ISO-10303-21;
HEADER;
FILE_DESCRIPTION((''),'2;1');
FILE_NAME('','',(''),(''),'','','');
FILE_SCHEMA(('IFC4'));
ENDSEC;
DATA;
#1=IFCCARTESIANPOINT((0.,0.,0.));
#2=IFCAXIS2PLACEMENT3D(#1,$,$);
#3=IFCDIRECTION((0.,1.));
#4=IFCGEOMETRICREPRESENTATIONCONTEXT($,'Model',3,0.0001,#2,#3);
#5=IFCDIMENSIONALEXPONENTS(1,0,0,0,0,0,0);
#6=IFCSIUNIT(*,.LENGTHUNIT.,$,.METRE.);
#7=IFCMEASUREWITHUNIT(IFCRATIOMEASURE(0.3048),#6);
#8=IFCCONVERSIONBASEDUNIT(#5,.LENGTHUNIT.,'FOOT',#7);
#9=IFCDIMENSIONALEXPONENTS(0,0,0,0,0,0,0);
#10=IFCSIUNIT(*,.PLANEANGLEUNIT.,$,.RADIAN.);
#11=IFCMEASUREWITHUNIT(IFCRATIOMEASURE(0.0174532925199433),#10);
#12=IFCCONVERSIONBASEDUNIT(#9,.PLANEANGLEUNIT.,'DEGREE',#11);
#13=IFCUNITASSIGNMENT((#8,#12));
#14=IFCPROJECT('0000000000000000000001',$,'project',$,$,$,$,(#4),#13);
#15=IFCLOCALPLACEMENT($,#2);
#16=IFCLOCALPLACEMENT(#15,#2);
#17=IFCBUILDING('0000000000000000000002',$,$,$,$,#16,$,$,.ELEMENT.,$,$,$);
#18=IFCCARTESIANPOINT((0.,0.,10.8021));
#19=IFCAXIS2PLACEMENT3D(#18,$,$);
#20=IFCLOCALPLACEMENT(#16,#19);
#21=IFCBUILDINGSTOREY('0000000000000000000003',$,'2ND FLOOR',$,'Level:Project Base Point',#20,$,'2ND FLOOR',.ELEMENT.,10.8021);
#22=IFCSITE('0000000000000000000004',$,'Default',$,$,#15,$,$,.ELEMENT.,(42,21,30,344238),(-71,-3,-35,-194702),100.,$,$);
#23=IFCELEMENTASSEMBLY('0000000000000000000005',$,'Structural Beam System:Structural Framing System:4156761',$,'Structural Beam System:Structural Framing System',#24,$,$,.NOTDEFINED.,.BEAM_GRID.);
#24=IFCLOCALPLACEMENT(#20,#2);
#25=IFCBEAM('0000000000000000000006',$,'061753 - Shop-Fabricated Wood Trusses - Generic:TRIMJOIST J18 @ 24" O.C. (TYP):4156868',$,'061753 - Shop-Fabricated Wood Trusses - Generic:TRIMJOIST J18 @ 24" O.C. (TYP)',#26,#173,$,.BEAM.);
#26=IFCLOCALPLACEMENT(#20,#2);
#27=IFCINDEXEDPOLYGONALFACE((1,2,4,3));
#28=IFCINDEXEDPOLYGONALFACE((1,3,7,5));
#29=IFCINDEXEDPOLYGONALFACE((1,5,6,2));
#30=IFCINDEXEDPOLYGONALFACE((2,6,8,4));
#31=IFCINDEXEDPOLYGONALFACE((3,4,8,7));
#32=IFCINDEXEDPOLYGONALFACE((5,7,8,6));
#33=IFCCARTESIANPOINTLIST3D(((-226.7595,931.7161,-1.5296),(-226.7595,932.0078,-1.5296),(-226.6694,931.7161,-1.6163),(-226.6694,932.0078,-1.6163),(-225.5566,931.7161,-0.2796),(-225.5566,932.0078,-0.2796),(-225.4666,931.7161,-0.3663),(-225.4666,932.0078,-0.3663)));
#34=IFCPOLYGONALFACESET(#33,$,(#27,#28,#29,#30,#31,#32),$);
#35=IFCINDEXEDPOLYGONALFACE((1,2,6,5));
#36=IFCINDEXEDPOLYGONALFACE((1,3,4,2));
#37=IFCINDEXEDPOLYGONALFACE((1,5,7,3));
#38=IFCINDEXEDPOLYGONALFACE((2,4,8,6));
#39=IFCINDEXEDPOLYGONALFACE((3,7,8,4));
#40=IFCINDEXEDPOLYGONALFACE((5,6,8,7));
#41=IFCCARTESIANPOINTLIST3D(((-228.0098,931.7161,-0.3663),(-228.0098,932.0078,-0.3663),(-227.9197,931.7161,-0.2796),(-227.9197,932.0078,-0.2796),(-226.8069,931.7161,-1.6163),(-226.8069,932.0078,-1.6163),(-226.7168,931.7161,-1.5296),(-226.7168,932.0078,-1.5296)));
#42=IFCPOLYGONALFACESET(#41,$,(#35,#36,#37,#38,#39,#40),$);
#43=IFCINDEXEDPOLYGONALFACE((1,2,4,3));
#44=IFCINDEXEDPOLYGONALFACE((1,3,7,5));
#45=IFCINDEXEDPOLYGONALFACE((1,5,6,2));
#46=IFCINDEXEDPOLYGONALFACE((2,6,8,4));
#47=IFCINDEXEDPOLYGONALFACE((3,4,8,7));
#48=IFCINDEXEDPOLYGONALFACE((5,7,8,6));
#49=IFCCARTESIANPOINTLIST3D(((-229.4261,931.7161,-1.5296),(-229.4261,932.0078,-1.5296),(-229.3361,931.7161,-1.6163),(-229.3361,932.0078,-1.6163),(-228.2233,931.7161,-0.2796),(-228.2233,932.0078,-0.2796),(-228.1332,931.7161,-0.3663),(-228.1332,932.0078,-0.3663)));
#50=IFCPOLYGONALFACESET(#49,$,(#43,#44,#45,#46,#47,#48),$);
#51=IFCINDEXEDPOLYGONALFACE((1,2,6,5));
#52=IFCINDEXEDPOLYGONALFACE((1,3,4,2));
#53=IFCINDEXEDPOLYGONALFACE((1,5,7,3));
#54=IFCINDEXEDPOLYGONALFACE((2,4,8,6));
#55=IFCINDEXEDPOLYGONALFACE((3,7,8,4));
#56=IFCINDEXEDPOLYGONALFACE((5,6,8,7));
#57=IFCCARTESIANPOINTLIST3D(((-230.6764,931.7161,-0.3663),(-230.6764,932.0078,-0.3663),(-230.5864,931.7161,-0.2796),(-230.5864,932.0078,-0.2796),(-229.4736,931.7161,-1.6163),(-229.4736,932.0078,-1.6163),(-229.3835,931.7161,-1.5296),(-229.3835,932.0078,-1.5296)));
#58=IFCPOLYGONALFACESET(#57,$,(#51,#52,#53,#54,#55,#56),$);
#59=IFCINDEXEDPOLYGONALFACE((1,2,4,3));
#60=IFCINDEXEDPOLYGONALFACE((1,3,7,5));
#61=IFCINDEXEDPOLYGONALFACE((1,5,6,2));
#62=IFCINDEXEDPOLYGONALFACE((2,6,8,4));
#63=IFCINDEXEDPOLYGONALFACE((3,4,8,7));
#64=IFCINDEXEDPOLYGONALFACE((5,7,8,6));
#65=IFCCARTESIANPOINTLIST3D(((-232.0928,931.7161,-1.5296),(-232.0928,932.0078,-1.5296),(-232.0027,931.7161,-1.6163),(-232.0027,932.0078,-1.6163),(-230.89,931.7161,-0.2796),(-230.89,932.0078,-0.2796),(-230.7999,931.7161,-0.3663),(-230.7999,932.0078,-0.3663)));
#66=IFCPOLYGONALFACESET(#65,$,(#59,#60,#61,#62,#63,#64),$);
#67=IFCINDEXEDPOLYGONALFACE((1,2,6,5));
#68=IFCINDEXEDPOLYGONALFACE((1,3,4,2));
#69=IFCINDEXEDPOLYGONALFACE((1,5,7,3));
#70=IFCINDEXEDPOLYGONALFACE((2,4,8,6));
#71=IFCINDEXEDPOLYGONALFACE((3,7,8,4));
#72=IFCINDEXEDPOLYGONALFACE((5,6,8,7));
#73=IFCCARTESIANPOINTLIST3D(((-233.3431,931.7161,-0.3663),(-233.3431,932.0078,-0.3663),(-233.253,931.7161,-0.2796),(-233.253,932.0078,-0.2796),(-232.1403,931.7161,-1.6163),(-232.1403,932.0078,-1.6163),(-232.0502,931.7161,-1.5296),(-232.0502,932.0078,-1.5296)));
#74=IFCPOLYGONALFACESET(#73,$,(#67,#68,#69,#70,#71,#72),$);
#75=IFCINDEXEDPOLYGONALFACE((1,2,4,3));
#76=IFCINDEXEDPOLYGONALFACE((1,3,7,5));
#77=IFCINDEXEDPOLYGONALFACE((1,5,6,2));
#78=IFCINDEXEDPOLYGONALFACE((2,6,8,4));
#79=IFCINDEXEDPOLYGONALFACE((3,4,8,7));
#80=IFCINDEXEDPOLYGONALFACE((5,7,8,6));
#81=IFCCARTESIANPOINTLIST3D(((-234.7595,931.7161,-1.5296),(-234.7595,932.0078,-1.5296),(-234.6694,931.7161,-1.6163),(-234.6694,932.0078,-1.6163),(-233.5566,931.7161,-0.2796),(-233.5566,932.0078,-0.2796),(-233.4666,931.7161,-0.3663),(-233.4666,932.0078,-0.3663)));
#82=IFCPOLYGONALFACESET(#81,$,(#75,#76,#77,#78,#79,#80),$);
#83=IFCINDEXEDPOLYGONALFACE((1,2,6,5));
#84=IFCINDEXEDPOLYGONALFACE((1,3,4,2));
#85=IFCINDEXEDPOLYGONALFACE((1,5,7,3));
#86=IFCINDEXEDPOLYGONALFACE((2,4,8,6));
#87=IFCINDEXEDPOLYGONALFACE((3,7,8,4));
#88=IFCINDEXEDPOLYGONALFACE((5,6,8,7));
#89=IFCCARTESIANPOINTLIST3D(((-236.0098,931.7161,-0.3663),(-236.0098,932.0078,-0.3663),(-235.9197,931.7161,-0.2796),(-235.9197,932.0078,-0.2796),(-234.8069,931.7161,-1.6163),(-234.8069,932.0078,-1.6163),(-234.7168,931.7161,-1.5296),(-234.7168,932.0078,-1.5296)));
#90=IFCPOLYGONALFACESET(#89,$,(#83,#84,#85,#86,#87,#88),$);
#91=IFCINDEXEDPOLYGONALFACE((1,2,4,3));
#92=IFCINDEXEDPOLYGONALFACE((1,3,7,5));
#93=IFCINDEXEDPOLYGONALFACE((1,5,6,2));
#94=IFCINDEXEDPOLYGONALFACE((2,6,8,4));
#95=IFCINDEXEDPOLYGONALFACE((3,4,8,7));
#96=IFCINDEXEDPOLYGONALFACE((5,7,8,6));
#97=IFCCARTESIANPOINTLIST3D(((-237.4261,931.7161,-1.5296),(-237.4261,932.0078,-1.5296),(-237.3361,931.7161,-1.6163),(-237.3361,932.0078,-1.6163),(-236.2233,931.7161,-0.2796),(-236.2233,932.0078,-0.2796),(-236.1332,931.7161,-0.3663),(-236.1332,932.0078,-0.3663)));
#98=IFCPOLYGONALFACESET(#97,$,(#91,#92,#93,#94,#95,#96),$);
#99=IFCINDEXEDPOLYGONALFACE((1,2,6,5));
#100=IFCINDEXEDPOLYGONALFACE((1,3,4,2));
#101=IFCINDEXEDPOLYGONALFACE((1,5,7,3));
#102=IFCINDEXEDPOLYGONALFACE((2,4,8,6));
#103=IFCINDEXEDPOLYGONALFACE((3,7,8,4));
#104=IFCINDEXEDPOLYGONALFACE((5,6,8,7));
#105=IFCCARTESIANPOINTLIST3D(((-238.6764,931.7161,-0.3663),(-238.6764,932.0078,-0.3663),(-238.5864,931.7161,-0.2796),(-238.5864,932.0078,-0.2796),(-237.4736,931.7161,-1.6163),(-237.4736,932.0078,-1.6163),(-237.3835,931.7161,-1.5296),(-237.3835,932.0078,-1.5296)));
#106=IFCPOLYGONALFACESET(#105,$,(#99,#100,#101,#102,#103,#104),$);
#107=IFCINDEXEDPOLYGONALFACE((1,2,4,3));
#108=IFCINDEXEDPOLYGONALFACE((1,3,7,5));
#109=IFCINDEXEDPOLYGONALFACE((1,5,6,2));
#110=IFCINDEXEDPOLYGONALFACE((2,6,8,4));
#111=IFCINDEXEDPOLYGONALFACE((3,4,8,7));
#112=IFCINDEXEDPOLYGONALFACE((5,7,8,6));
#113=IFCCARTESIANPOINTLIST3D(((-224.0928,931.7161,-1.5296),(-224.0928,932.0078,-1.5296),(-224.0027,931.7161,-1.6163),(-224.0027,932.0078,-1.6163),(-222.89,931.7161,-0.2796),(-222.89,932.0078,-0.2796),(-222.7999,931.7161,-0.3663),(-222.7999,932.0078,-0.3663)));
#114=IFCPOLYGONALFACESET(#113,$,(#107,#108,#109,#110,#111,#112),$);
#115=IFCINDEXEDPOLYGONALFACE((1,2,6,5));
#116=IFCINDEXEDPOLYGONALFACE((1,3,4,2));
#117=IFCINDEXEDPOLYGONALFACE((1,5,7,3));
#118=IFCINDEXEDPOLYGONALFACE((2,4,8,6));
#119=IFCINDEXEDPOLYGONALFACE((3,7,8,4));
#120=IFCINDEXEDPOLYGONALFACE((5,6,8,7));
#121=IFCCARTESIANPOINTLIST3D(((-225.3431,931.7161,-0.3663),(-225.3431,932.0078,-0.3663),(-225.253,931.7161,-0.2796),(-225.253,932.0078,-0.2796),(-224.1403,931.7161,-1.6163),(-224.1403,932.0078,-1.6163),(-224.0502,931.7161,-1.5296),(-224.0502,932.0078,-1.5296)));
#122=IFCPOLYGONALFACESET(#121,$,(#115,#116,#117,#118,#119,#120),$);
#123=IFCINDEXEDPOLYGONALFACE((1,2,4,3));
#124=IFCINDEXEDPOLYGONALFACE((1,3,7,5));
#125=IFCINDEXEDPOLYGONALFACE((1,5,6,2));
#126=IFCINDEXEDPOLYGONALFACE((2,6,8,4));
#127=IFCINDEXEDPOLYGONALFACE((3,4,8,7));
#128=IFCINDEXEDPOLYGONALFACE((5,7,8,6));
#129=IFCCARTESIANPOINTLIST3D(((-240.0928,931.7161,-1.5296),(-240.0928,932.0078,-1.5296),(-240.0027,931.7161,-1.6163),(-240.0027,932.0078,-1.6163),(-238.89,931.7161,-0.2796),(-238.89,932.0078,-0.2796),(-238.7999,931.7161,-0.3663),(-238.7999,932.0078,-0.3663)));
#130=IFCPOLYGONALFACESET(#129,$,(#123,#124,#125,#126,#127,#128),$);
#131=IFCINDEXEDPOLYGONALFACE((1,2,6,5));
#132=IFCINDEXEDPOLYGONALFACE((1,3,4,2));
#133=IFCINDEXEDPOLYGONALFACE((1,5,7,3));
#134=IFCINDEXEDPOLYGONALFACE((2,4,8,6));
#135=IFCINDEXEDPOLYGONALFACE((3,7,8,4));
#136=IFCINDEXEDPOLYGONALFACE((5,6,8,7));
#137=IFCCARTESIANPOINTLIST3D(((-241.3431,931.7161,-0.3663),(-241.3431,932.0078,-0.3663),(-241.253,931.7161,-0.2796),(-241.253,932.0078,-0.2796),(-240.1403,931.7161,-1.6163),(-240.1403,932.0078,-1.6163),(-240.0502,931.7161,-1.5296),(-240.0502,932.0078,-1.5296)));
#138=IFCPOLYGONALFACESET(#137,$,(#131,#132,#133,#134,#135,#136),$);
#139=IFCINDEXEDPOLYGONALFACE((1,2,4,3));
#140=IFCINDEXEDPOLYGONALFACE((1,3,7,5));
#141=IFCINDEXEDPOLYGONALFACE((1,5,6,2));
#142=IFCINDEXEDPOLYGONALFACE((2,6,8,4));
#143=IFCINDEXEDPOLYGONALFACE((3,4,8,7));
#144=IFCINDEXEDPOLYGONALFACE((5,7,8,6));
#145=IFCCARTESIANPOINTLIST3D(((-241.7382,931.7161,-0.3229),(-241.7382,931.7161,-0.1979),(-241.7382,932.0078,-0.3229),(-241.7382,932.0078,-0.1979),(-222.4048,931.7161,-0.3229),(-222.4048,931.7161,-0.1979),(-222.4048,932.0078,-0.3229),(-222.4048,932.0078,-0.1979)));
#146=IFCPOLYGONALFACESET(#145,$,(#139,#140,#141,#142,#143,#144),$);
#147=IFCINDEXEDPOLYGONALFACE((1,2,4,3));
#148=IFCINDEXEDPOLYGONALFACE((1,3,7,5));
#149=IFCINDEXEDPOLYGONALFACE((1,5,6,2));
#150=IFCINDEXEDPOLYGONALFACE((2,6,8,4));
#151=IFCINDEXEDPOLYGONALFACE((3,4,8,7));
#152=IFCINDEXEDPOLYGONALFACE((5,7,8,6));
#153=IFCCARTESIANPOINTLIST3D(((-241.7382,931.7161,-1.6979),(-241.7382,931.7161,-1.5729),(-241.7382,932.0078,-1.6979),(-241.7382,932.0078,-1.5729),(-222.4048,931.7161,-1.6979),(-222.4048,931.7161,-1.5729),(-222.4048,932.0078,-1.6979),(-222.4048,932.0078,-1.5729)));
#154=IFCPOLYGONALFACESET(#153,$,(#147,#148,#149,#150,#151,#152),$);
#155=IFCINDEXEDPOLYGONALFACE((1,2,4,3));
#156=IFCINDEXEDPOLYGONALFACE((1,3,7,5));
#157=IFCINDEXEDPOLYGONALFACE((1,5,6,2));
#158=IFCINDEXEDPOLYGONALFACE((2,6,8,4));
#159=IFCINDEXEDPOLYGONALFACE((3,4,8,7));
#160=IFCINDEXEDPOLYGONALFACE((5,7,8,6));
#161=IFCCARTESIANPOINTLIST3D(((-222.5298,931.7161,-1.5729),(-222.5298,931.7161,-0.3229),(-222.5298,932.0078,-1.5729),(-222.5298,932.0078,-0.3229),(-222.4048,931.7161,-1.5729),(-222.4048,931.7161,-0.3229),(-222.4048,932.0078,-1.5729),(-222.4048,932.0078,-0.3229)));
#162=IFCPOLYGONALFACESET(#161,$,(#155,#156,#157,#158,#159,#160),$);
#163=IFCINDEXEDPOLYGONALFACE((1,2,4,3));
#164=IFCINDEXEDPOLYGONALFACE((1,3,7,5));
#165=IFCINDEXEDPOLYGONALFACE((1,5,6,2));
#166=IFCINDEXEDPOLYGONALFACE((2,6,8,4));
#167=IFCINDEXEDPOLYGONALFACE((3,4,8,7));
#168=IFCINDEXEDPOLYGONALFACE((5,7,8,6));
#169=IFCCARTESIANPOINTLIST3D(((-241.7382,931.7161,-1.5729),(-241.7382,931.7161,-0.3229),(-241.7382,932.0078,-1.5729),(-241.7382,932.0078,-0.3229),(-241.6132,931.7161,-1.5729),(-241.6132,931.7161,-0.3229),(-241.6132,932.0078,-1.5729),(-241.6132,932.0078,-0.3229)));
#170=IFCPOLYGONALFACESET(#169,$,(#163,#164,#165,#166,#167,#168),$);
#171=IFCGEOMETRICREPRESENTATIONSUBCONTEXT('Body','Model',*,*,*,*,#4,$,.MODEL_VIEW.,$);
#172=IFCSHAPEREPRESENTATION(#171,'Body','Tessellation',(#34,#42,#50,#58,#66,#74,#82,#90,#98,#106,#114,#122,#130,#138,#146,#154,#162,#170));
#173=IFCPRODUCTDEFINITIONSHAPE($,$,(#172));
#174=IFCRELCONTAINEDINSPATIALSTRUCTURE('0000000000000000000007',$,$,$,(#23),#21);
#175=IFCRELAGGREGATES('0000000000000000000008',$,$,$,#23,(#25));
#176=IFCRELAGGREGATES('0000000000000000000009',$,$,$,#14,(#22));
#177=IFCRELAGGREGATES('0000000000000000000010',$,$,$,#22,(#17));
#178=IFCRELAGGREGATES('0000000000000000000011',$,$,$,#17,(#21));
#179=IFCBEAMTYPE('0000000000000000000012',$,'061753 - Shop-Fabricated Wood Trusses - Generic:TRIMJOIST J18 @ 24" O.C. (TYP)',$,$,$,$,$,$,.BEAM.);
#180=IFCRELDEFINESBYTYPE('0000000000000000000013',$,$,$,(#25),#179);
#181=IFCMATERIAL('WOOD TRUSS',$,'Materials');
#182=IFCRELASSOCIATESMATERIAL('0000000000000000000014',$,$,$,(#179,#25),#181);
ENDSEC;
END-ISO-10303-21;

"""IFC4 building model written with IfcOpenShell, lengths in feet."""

from ifc_helpers import new_model, entity, si_unit, converted_unit, direction, frame, frame_2d, origin, origin_2d_with_axis, place, context, subcontext, project, spatial, rectangle, extrude, source, transform, mapped, material, material_profile, profile_set, profile_usage, type_object, type_shapes, element, aggregate, save


model = new_model("IFC4")

# Units and contexts
model_context = context("Model", 3, precision=0.0001, world=origin(), true_north=direction((0.0, 1.0)))
body_context = subcontext(model_context, "Body", "Model", "MODEL_VIEW")
ifc_project = project(units=[converted_unit("LENGTHUNIT", "FOOT", entity("IfcRatioMeasure", 0.3048), si_unit("LENGTHUNIT", "METRE"), dimensions=[1, 0, 0, 0, 0, 0, 0]), converted_unit("PLANEANGLEUNIT", "DEGREE", entity("IfcRatioMeasure", 0.0174532925199433), si_unit("PLANEANGLEUNIT", "RADIAN"), dimensions=[0, 0, 0, 0, 0, 0, 0])], contexts=[model_context])

# Site, building, storey
site_placement = place(None, origin())
site = spatial("IfcSite", under=ifc_project, at=site_placement, Name="Default", CompositionType="ELEMENT", RefLatitude=(42, 21, 30, 344238), RefLongitude=(-71, -3, -35, -194702), RefElevation=100.0)
building_placement = place(site_placement, origin())
building = spatial("IfcBuilding", under=site, at=building_placement, CompositionType="ELEMENT")
storey_placement = place(building_placement, frame((0.0, 0.0, 10.8021)))
storey = spatial("IfcBuildingStorey", under=building, at=storey_placement, Name="2ND FLOOR", ObjectType="Level:Project Base Point", LongName="2ND FLOOR", CompositionType="ELEMENT", Elevation=10.8021)

# Element assembly, beam
ifc_material_1 = material(Name="WOOD TRUSS", Category="Materials")
ifc_material_profile_1 = material_profile(ifc_material_1, rectangle(XDim=1.7347, YDim=0.125, at=frame_2d((0.0, 0.0), x_axis=(1.0, 0.0))), Name="TRIMJOIST J18 @ 24\" O.C. (TYP)")
ifc_material_profile_2 = material_profile(ifc_material_1, rectangle(XDim=1.7347, YDim=0.125, at=frame_2d((0.0, 0.0), x_axis=(1.0, 0.0))), Name="TRIMJOIST J18 @ 24\" O.C. (TYP)")
ifc_material_profile_3 = material_profile(ifc_material_1, rectangle(XDim=1.7347, YDim=0.125, at=frame_2d((0.0, 0.0), x_axis=(1.0, 0.0))), Name="TRIMJOIST J18 @ 24\" O.C. (TYP)")
ifc_material_profile_4 = material_profile(ifc_material_1, rectangle(XDim=1.7347, YDim=0.125, at=frame_2d((0.0, 0.0), x_axis=(1.0, 0.0))), Name="TRIMJOIST J18 @ 24\" O.C. (TYP)")
ifc_material_profile_5 = material_profile(ifc_material_1, rectangle(XDim=1.7347, YDim=0.125, at=frame_2d((0.0, 0.0), x_axis=(1.0, 0.0))), Name="TRIMJOIST J18 @ 24\" O.C. (TYP)")
ifc_material_profile_6 = material_profile(ifc_material_1, rectangle(XDim=1.7347, YDim=0.125, at=frame_2d((0.0, 0.0), x_axis=(1.0, 0.0))), Name="TRIMJOIST J18 @ 24\" O.C. (TYP)")
ifc_material_profile_7 = material_profile(ifc_material_1, rectangle(XDim=1.7347, YDim=0.125, at=frame_2d((0.0, 0.0), x_axis=(1.0, 0.0))), Name="TRIMJOIST J18 @ 24\" O.C. (TYP)")
ifc_material_profile_8 = material_profile(ifc_material_1, rectangle(XDim=1.7347, YDim=0.125, at=frame_2d((0.0, 0.0), x_axis=(1.0, 0.0))), Name="TRIMJOIST J18 @ 24\" O.C. (TYP)")
ifc_material_profile_9 = material_profile(ifc_material_1, rectangle(XDim=1.7347, YDim=0.125, at=frame_2d((0.0, 0.0), x_axis=(1.0, 0.0))), Name="TRIMJOIST J18 @ 24\" O.C. (TYP)")
ifc_material_profile_10 = material_profile(ifc_material_1, rectangle(XDim=1.7347, YDim=0.125, at=origin_2d_with_axis()), Name="TRIMJOIST J18 @ 24\" O.C. (TYP)")
ifc_material_profile_11 = material_profile(ifc_material_1, rectangle(XDim=0.125, YDim=0.2917, at=origin_2d_with_axis()), Name="TRIMJOIST J18 @ 24\" O.C. (TYP)")
ifc_material_profile_12 = material_profile(ifc_material_1, rectangle(XDim=0.125, YDim=0.2917, at=origin_2d_with_axis()), Name="TRIMJOIST J18 @ 24\" O.C. (TYP)")
ifc_material_profile_13 = material_profile(ifc_material_1, rectangle(XDim=1.25, YDim=0.2917, at=origin_2d_with_axis()), Name="TRIMJOIST J18 @ 24\" O.C. (TYP)")
ifc_material_profile_14 = material_profile(ifc_material_1, rectangle(XDim=1.25, YDim=0.2917, at=origin_2d_with_axis()), Name="TRIMJOIST J18 @ 24\" O.C. (TYP)")
ifc_profile_set_1 = profile_set([ifc_material_profile_1, ifc_material_profile_2, ifc_material_profile_3, ifc_material_profile_4, ifc_material_profile_5, ifc_material_profile_6, ifc_material_profile_7, ifc_material_profile_8, ifc_material_profile_9, ifc_material_profile_10, ifc_material_profile_11, ifc_material_profile_12, ifc_material_profile_13, ifc_material_profile_14], Name="TRIMJOIST J18 @ 24\" O.C. (TYP)")
assembly_1_placement = place(storey_placement, origin())
assembly_1 = element("IfcElementAssembly", 1, at=assembly_1_placement, inside=storey, Name="Structural Beam System:Structural Framing System:4156761", ObjectType="Structural Beam System:Structural Framing System", AssemblyPlace="NOTDEFINED", PredefinedType="BEAM_GRID")
beam_type_1 = type_object("IfcBeamType", Name="061753 - Shop-Fabricated Wood Trusses - Generic:TRIMJOIST J18 @ 24\" O.C. (TYP)", PredefinedType="BEAM", material=ifc_profile_set_1)
shared_shape_1 = source(origin(), body_context, "Body", "SweptSolid", [
    extrude(rectangle(XDim=1.7347, YDim=0.125, at=frame_2d((0.0, 0.0), x_axis=(1.0, 0.0))), frame((5.9585, -0.1458, 0.0), z_axis=(0.0, 1.0, 0.0), x_axis=(0.693383, 0.0, 0.720569)), (0.0, 0.0, 1.0), 0.2917),
    extrude(rectangle(XDim=1.7347, YDim=0.125, at=origin_2d_with_axis()), frame((4.7082, -0.1458, 0.0), z_axis=(0.0, 1.0, 0.0), x_axis=(0.693383, 0.0, -0.720569)), (0.0, 0.0, 1.0), 0.2917),
    extrude(rectangle(XDim=1.7347, YDim=0.125, at=frame_2d((0.0, 0.0), x_axis=(1.0, 0.0))), frame((3.2918, -0.1458, 0.0), z_axis=(0.0, 1.0, 0.0), x_axis=(0.693383, 0.0, 0.720569)), (0.0, 0.0, 1.0), 0.2917),
    extrude(rectangle(XDim=1.7347, YDim=0.125, at=frame_2d((0.0, 0.0), x_axis=(1.0, 0.0))), frame((2.0415, -0.1458, 0.0), z_axis=(0.0, 1.0, 0.0), x_axis=(0.693383, 0.0, -0.720569)), (0.0, 0.0, 1.0), 0.2917),
    extrude(rectangle(XDim=1.7347, YDim=0.125, at=frame_2d((0.0, 0.0), x_axis=(1.0, 0.0))), frame((0.6251, -0.1458, 0.0), z_axis=(0.0, 1.0, 0.0), x_axis=(0.693383, 0.0, 0.720569)), (0.0, 0.0, 1.0), 0.2917),
    extrude(rectangle(XDim=1.7347, YDim=0.125, at=frame_2d((0.0, 0.0), x_axis=(1.0, 0.0))), frame((-0.6251, -0.1458, 0.0), z_axis=(0.0, 1.0, 0.0), x_axis=(0.693383, 0.0, -0.720569)), (0.0, 0.0, 1.0), 0.2917),
    extrude(rectangle(XDim=1.7347, YDim=0.125, at=frame_2d((0.0, 0.0), x_axis=(1.0, 0.0))), frame((-2.0415, -0.1458, 0.0), z_axis=(0.0, 1.0, 0.0), x_axis=(0.693383, 0.0, 0.720569)), (0.0, 0.0, 1.0), 0.2917),
    extrude(rectangle(XDim=1.7347, YDim=0.125, at=origin_2d_with_axis()), frame((-3.2918, -0.1458, 0.0), z_axis=(0.0, 1.0, 0.0), x_axis=(0.693383, 0.0, -0.720569)), (0.0, 0.0, 1.0), 0.2917),
    extrude(rectangle(XDim=1.7347, YDim=0.125, at=frame_2d((0.0, 0.0), x_axis=(1.0, 0.0))), frame((-4.7082, -0.1458, 0.0), z_axis=(0.0, 1.0, 0.0), x_axis=(0.693383, 0.0, 0.720569)), (0.0, 0.0, 1.0), 0.2917),
    extrude(rectangle(XDim=1.7347, YDim=0.125, at=frame_2d((0.0, 0.0), x_axis=(1.0, 0.0))), frame((-5.9585, -0.1458, 0.0), z_axis=(0.0, 1.0, 0.0), x_axis=(0.693383, 0.0, -0.720569)), (0.0, 0.0, 1.0), 0.2917),
    extrude(rectangle(XDim=1.7347, YDim=0.125, at=frame_2d((0.0, 0.0), x_axis=(1.0, 0.0))), frame((8.6251, -0.1458, 0.0), z_axis=(0.0, 1.0, 0.0), x_axis=(0.693383, 0.0, 0.720569)), (0.0, 0.0, 1.0), 0.2917),
    extrude(rectangle(XDim=1.7347, YDim=0.125, at=origin_2d_with_axis()), frame((7.3749, -0.1458, 0.0), z_axis=(0.0, 1.0, 0.0), x_axis=(0.693383, 0.0, -0.720569)), (0.0, 0.0, 1.0), 0.2917),
    extrude(rectangle(XDim=1.7347, YDim=0.125, at=frame_2d((0.0, 0.0), x_axis=(1.0, 0.0))), frame((-7.3749, -0.1458, 0.0), z_axis=(0.0, 1.0, 0.0), x_axis=(0.693383, 0.0, 0.720569)), (0.0, 0.0, 1.0), 0.2917),
    extrude(rectangle(XDim=1.7347, YDim=0.125, at=origin_2d_with_axis()), frame((-8.6251, -0.1458, 0.0), z_axis=(0.0, 1.0, 0.0), x_axis=(0.693383, 0.0, -0.720569)), (0.0, 0.0, 1.0), 0.2917),
    extrude(rectangle(XDim=0.125, YDim=0.2917, at=origin_2d_with_axis()), frame((-9.6667, 0.0, 0.6875), z_axis=(1.0, 0.0, 0.0), x_axis=(0.0, 0.0, -1.0)), (0.0, 0.0, 1.0), 19.3333),
    extrude(rectangle(XDim=0.125, YDim=0.2917, at=origin_2d_with_axis()), frame((-9.6667, 0.0, -0.6875), z_axis=(1.0, 0.0, 0.0), x_axis=(0.0, 0.0, -1.0)), (0.0, 0.0, 1.0), 19.3333),
    extrude(rectangle(XDim=1.25, YDim=0.2917, at=origin_2d_with_axis()), frame((9.5417, 0.0, 0.0), z_axis=(1.0, 0.0, 0.0), x_axis=(0.0, 0.0, -1.0)), (0.0, 0.0, 1.0), 0.125),
    extrude(rectangle(XDim=1.25, YDim=0.2917, at=origin_2d_with_axis()), frame((-9.6667, 0.0, 0.0), z_axis=(1.0, 0.0, 0.0), x_axis=(0.0, 0.0, -1.0)), (0.0, 0.0, 1.0), 0.125),
])
type_shapes(beam_type_1, [shared_shape_1])
ifc_profile_usage_1 = profile_usage(ifc_profile_set_1, cardinal=8)
beam_1_placement = place(assembly_1_placement, frame((-232.0715, 931.8619, -0.9479)))
beam_1 = element("IfcBeam", 2, at=beam_1_placement, type_object=beam_type_1, material=ifc_profile_usage_1, Name="061753 - Shop-Fabricated Wood Trusses - Generic:TRIMJOIST J18 @ 24\" O.C. (TYP):4156868", ObjectType="061753 - Shop-Fabricated Wood Trusses - Generic:TRIMJOIST J18 @ 24\" O.C. (TYP)", PredefinedType="BEAM", context=body_context, shape_type="MappedRepresentation", body=[
    mapped(shared_shape_1, transform((0.0, 0.0, 0.0), scale=1.0)),
])
aggregate(assembly_1, [beam_1])

save(model, "model.ifc")
